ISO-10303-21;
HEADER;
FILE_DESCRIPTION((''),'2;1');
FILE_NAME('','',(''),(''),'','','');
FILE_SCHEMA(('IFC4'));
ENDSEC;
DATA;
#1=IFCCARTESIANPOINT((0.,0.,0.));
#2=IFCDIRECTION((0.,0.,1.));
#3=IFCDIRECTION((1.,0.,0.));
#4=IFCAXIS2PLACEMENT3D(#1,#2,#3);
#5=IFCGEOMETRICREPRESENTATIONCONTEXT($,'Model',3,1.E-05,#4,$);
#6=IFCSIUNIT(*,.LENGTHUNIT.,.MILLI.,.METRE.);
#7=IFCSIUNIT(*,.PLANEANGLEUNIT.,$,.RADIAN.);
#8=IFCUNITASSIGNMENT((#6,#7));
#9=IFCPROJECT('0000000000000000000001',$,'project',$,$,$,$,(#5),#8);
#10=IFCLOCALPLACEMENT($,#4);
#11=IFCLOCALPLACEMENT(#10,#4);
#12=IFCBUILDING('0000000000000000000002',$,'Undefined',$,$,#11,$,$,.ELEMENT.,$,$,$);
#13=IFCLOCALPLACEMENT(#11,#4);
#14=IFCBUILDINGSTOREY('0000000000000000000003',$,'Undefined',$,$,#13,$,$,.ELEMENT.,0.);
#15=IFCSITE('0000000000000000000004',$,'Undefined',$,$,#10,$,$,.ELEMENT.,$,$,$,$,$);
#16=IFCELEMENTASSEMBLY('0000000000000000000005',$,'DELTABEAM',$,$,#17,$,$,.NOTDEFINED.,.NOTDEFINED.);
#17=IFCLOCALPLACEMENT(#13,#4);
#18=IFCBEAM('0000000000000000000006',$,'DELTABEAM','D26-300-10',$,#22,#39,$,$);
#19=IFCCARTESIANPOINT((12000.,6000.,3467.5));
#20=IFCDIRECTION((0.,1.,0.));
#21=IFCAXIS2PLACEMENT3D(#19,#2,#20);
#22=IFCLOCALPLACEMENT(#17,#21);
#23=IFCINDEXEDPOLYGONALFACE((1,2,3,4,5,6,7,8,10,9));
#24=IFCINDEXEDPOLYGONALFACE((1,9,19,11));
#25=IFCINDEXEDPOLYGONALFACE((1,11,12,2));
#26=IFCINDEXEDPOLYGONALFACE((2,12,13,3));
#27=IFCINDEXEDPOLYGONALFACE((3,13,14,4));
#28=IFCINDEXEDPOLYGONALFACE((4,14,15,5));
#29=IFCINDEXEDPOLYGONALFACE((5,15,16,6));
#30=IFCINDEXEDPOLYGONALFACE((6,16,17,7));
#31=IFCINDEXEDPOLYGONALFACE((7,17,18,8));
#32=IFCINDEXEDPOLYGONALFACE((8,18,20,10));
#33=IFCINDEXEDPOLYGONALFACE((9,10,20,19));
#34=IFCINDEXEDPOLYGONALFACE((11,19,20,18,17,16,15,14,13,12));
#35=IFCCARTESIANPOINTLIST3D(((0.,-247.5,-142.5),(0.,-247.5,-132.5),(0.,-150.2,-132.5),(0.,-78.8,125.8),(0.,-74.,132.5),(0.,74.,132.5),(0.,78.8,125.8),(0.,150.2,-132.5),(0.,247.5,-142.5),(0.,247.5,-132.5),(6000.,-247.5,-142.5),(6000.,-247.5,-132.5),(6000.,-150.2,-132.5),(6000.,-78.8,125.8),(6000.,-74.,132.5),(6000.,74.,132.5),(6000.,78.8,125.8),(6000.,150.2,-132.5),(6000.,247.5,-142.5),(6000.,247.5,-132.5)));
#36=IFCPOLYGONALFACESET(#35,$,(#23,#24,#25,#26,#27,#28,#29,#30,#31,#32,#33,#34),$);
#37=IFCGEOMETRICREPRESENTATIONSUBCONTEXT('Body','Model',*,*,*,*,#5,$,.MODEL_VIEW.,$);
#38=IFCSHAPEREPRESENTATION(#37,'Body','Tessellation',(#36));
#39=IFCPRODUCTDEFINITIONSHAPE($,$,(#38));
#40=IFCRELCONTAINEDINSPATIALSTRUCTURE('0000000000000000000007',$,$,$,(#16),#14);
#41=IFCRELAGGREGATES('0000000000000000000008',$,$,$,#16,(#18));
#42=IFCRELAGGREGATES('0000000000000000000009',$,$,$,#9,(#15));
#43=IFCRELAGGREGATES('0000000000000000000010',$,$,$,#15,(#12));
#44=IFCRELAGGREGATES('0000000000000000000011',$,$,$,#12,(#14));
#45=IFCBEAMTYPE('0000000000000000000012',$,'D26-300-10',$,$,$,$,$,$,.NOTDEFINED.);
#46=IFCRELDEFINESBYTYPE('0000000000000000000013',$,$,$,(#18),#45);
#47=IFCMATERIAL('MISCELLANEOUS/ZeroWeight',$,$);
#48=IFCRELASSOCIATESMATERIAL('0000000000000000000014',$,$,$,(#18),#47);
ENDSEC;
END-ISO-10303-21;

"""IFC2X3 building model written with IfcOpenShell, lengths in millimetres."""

from ifc_helpers import new_model, si_unit, frame, origin_with_axes, place, context, subcontext, project, spatial, polyline, outline, extrude, material, type_object, element, aggregate, save


model = new_model("IFC2X3")

# Units and contexts
model_context = context("Model", 3, precision=1e-05, world=origin_with_axes())
body_context = subcontext(model_context, "Body", "Model", "MODEL_VIEW")
ifc_project = project(units=[si_unit("LENGTHUNIT", "METRE", prefix="MILLI"), si_unit("PLANEANGLEUNIT", "RADIAN")], contexts=[model_context])

# Site, building, storey
site_placement = place(None, origin_with_axes())
site = spatial("IfcSite", under=ifc_project, at=site_placement, Name="Undefined", CompositionType="ELEMENT")
building_placement = place(site_placement, origin_with_axes())
building = spatial("IfcBuilding", under=site, at=building_placement, Name="Undefined", CompositionType="ELEMENT")
storey_placement = place(building_placement, origin_with_axes())
storey = spatial("IfcBuildingStorey", under=building, at=storey_placement, Name="Undefined", CompositionType="ELEMENT", Elevation=0.0)

# Element assembly, beam
assembly_1_placement = place(storey_placement, origin_with_axes())
assembly_1 = element("IfcElementAssembly", 1, at=assembly_1_placement, inside=storey, Name="DELTABEAM", AssemblyPlace="NOTDEFINED", PredefinedType="NOTDEFINED")
ifc_material_1 = material(Name="MISCELLANEOUS/ZeroWeight")
beam_type = type_object("IfcBeamType", Name="D26-300-10", PredefinedType="NOTDEFINED")
beam_placement = place(assembly_1_placement, frame((12000.0, 6000.0, 3467.5), z_axis=(0.0, 0.0, 1.0), x_axis=(0.0, 1.0, 0.0)))
beam = element("IfcBeam", 2, at=beam_placement, type_object=beam_type, material=ifc_material_1, Name="DELTABEAM", Description="D26-300-10", context=body_context, shape_type="SweptSolid", body=[
    extrude(outline(polyline([(-75.1, 120.5), (-145.0, -132.5), (247.5, -132.5), (247.5, -142.5), (-247.5, -142.5), (-247.5, -132.5), (-150.2, -132.5), (-78.8, 125.8), (-74.0, 132.5), (74.0, 132.5), (78.8, 125.8), (150.2, -132.5), (145.0, -132.5), (75.1, 120.5), (-75.1, 120.5)])), frame((6000.0, 0.0, 0.0), z_axis=(-1.0, 0.0, 0.0), x_axis=(0.0, -1.0, 0.0)), (0.0, 0.0, 1.0), 6000.0),
])
aggregate(assembly_1, [beam])

save(model, "model.ifc")
